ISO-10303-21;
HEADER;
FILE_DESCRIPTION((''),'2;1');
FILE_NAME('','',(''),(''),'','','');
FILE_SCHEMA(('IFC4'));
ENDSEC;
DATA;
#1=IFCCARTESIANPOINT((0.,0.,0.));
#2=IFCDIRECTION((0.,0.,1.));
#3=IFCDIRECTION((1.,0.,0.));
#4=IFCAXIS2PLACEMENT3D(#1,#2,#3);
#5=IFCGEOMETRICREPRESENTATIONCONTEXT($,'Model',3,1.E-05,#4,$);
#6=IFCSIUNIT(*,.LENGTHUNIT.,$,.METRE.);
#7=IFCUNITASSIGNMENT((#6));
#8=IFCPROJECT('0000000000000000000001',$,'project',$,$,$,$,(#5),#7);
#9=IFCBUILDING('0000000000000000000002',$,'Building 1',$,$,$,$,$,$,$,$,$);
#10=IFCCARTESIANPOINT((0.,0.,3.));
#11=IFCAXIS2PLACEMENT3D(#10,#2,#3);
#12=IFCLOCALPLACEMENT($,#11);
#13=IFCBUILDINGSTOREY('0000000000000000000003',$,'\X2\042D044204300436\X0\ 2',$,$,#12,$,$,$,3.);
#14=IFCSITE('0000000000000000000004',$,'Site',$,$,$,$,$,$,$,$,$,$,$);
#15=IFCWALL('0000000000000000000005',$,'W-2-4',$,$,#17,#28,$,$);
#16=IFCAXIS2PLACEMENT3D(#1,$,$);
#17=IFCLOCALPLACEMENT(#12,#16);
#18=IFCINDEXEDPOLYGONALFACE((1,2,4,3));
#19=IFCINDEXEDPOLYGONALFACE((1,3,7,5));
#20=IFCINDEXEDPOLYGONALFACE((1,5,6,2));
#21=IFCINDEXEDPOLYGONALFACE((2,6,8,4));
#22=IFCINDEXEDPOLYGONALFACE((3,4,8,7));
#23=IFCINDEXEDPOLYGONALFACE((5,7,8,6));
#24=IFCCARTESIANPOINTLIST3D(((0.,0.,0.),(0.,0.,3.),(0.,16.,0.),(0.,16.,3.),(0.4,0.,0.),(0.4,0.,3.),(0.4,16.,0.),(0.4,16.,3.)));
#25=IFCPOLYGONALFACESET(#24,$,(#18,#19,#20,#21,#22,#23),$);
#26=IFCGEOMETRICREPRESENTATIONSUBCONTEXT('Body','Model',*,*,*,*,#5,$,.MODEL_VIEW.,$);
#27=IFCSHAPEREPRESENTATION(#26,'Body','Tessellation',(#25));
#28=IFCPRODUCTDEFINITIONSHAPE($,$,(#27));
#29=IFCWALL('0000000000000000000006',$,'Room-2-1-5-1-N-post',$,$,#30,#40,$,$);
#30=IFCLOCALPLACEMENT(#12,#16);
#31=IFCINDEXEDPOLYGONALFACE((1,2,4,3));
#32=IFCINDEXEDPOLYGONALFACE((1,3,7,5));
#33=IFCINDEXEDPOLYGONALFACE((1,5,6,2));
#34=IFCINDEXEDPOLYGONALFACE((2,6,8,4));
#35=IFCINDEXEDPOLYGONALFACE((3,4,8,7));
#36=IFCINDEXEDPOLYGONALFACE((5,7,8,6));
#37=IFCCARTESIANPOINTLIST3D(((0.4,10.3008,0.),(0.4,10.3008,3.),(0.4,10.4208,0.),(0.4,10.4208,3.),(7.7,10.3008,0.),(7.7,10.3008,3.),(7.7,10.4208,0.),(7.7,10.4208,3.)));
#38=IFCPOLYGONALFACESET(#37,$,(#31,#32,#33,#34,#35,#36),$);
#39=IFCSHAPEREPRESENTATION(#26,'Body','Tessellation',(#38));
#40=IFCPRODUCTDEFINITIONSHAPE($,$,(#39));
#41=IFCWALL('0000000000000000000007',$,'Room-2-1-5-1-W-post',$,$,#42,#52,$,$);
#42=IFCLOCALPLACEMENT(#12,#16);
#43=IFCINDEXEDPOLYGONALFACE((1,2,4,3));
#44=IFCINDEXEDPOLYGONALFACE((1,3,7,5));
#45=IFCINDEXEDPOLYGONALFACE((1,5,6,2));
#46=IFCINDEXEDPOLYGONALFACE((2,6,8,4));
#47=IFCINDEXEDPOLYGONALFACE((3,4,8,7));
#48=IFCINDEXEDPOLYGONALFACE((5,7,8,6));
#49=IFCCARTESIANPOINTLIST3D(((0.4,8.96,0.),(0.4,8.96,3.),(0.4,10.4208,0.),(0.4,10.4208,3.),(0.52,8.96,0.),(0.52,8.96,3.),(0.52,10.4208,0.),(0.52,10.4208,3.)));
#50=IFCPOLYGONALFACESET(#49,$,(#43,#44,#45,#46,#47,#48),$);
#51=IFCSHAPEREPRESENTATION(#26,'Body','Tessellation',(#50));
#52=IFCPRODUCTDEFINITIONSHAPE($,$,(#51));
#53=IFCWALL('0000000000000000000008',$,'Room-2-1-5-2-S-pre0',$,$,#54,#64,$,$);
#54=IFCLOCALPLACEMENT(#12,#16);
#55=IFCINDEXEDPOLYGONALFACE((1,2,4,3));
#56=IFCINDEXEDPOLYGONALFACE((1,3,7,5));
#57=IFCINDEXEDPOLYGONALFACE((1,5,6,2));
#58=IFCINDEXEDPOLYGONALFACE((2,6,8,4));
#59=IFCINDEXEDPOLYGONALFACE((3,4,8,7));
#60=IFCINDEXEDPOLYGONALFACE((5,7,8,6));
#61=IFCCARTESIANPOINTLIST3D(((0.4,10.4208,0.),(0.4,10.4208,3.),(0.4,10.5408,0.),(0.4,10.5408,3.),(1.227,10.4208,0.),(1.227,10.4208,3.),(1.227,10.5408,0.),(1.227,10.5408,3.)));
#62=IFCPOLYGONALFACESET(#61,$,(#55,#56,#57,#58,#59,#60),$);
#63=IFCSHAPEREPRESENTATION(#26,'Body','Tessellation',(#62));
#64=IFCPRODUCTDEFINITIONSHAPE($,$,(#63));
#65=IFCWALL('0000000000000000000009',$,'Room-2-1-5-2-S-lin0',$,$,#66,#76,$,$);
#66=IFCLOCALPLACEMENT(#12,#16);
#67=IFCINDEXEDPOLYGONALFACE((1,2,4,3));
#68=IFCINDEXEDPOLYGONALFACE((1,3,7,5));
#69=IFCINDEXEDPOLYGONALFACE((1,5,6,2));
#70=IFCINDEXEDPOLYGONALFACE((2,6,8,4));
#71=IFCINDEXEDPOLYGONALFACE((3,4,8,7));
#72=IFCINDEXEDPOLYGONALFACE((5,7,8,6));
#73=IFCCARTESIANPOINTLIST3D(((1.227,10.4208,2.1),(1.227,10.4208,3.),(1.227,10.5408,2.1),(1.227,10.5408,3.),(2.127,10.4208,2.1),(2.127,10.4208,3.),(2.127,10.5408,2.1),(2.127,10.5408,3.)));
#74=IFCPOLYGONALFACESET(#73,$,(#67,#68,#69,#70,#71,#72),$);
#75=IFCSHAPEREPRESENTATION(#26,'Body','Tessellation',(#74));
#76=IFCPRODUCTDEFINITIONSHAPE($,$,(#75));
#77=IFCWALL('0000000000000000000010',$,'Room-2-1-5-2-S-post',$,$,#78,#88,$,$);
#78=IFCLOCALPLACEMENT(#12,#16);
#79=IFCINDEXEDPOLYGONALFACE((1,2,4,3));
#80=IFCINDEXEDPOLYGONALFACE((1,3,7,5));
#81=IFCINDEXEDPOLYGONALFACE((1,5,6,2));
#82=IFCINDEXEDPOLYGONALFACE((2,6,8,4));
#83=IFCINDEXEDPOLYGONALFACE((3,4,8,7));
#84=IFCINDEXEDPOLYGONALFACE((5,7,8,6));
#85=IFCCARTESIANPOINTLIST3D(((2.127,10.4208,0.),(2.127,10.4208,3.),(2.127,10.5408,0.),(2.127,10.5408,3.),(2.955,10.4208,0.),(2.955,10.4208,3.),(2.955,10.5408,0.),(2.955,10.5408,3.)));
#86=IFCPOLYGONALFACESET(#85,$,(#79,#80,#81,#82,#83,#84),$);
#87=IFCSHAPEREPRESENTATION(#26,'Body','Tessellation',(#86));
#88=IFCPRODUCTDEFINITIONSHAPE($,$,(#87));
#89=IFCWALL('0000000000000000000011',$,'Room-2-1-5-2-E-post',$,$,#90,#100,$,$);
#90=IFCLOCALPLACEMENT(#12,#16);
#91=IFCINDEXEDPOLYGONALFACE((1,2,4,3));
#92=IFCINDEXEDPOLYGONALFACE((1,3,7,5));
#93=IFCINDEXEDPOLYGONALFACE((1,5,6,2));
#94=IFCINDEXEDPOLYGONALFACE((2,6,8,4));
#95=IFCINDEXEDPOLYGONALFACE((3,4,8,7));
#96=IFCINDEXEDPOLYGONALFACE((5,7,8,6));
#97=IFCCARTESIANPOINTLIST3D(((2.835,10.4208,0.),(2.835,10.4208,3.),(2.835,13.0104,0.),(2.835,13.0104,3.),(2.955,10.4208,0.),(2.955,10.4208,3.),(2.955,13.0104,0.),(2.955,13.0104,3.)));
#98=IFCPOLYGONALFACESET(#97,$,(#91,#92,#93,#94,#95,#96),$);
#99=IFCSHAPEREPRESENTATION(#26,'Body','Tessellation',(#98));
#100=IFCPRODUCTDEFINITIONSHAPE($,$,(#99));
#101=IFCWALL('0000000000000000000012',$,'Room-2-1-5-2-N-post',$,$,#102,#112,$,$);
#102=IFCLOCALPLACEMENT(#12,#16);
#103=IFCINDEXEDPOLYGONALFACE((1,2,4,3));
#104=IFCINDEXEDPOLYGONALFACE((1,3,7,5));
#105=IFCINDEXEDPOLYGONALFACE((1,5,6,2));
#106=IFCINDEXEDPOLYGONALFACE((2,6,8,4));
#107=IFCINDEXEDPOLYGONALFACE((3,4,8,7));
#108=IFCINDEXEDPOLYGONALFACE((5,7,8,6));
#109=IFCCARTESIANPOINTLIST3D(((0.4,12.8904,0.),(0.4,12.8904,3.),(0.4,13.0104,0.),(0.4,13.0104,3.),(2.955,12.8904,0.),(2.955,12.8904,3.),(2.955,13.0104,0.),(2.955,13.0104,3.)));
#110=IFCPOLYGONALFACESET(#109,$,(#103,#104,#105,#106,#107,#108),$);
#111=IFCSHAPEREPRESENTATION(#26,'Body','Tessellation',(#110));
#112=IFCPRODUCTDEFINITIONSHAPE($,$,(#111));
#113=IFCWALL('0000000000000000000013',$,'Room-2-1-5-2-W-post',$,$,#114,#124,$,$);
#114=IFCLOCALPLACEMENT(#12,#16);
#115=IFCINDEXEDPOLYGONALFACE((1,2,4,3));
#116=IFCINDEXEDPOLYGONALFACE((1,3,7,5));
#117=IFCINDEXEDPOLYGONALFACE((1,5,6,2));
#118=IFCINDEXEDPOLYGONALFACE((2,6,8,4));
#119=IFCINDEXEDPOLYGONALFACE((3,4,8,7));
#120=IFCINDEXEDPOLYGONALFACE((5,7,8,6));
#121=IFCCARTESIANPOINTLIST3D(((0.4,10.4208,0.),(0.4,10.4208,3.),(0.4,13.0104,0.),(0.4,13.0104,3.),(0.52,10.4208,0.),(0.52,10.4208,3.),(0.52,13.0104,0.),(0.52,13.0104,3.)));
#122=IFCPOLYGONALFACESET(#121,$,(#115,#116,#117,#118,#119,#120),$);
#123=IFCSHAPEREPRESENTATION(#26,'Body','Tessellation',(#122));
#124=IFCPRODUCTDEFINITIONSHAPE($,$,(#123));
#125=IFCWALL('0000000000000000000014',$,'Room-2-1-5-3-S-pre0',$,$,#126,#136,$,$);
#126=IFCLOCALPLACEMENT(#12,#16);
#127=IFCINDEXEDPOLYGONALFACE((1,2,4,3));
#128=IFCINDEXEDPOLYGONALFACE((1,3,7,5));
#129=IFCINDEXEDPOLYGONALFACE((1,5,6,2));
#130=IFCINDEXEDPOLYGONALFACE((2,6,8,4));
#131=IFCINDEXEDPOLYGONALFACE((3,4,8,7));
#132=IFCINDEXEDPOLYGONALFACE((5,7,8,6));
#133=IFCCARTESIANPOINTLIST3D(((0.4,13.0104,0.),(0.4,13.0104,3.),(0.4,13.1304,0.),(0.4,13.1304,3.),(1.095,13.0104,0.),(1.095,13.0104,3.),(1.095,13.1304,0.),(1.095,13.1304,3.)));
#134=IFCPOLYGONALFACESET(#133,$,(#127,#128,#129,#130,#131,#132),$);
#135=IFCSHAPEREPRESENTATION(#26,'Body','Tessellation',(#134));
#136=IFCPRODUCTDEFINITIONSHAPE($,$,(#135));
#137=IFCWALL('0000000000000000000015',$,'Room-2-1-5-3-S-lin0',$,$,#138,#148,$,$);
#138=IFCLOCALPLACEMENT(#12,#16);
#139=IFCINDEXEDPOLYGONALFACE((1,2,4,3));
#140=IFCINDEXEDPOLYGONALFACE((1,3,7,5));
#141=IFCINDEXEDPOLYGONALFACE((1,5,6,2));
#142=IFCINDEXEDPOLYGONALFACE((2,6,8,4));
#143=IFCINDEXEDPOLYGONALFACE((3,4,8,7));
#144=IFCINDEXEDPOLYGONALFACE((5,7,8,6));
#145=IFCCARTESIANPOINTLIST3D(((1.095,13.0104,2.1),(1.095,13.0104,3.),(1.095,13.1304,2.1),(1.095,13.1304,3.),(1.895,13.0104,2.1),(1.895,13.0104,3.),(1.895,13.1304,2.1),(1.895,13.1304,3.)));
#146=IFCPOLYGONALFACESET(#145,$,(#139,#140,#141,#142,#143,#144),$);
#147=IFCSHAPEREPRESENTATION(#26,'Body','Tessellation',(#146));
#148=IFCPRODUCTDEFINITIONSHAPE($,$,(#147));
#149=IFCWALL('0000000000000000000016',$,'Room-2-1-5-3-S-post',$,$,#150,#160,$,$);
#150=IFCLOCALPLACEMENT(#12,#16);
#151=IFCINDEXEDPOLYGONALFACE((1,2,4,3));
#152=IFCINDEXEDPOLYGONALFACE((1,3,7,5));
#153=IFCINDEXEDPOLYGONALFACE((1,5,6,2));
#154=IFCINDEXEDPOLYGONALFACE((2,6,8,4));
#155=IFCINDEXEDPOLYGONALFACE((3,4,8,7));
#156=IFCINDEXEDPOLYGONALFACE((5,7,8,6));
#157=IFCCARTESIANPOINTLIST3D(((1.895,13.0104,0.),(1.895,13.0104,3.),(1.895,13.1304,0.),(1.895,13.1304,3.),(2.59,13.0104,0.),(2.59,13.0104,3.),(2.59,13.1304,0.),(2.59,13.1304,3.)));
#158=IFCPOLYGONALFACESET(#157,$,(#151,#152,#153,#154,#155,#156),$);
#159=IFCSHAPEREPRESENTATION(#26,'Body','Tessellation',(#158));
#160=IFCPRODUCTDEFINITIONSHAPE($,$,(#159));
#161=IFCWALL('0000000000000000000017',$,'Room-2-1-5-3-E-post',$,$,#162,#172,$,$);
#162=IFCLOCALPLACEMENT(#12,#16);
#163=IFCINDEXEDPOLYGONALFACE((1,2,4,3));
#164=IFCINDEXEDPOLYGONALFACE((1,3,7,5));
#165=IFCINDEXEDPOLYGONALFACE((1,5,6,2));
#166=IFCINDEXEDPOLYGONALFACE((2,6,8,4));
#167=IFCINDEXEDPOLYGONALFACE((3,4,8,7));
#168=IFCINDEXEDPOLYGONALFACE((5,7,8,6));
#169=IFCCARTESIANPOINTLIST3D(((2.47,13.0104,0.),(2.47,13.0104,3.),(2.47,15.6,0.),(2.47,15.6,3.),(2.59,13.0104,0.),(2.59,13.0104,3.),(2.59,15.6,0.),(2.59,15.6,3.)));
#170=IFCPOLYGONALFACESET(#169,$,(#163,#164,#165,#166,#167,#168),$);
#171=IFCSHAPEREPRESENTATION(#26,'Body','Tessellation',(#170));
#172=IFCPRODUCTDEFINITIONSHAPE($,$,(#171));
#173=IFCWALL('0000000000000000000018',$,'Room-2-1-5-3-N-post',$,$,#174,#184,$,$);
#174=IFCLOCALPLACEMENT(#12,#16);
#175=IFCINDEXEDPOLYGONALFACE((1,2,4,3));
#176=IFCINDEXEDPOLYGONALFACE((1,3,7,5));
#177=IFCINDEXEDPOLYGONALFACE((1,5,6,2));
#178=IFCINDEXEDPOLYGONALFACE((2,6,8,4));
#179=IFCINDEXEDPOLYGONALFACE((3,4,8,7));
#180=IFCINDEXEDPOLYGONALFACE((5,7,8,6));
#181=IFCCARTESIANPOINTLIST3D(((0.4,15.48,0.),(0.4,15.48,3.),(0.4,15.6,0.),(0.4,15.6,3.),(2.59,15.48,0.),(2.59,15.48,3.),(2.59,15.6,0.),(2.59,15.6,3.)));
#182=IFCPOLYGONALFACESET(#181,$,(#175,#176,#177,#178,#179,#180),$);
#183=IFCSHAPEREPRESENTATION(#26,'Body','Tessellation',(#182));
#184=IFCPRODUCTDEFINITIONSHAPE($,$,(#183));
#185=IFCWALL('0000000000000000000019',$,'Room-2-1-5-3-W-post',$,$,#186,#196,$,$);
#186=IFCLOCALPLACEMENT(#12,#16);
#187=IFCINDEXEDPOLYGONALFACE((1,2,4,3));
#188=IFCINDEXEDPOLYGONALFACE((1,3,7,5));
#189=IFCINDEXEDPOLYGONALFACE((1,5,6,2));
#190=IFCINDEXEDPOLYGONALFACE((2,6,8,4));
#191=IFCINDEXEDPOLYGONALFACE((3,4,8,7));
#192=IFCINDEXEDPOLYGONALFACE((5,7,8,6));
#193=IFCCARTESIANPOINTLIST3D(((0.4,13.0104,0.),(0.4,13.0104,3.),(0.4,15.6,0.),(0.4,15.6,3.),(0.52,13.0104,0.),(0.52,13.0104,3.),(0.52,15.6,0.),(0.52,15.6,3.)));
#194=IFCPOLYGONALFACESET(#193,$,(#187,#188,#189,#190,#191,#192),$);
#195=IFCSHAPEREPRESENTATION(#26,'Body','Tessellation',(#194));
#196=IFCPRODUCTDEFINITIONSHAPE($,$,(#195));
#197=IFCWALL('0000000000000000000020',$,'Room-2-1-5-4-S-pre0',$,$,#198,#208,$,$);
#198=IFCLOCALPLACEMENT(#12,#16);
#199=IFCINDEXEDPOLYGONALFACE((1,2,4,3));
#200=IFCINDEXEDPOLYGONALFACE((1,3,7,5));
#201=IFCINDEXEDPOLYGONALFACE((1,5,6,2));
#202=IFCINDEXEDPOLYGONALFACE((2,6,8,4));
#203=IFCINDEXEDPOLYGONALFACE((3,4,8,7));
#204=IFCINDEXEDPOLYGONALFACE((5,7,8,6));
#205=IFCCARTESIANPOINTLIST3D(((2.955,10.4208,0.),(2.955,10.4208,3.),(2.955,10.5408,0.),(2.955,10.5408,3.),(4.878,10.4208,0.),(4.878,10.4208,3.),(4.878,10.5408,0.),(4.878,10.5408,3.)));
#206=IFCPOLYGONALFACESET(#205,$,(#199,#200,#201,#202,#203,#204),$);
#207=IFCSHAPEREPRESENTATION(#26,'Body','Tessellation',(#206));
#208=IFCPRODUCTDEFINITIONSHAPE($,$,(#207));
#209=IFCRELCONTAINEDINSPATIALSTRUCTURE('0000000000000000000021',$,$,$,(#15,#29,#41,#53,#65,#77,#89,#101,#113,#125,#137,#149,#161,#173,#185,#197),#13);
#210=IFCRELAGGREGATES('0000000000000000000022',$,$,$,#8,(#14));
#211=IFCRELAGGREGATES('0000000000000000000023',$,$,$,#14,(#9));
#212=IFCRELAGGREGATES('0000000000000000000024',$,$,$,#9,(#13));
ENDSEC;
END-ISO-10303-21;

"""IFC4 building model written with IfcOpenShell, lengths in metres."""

from ifc_helpers import new_model, si_unit, frame, origin_with_axes, place, context, subcontext, project, spatial, indexed_curve, outline, extrude, element, save


model = new_model("IFC4")

# Units and contexts
model_context = context("Model", 3, precision=1e-05, world=origin_with_axes())
body_context = subcontext(model_context, "Body", "Model", "MODEL_VIEW")
ifc_project = project(units=[si_unit("LENGTHUNIT", "METRE")], contexts=[model_context])

# Site, building, storey
site = spatial("IfcSite", under=ifc_project, Name="Site")
building = spatial("IfcBuilding", under=site, Name="Building 1")
storey_placement = place(None, frame((0.0, 0.0, 3.0), z_axis=(0.0, 0.0, 1.0), x_axis=(1.0, 0.0, 0.0)))
storey = spatial("IfcBuildingStorey", under=building, at=storey_placement, Name="Этаж 2", Elevation=3.0)

# Walls
wall_1_placement = place(storey_placement, frame((0.0, 16.0, 0.0), z_axis=(0.0, 0.0, 1.0), x_axis=(0.0, -1.0, 0.0)))
element("IfcWall", 1, at=wall_1_placement, inside=storey, Name="W-2-4", context=body_context, shape_type="SweptSolid", body=[
    extrude(outline(indexed_curve([(0.0, 0.0), (0.0, 0.4), (16.0, 0.4), (16.0, 0.0), (0.0, 0.0)], self_intersect=False)), origin_with_axes(), (0.0, 0.0, 1.0), 3.0),
])
wall_2_placement = place(storey_placement, frame((7.7, 10.4208, 0.0), z_axis=(0.0, 0.0, 1.0), x_axis=(-1.0, 0.0, 0.0)))
element("IfcWall", 2, at=wall_2_placement, inside=storey, Name="Room-2-1-5-1-N-post", context=body_context, shape_type="SweptSolid", body=[
    extrude(outline(indexed_curve([(0.0, 0.0), (0.0, 0.12), (7.3, 0.12), (7.3, 0.0), (0.0, 0.0)], self_intersect=False)), origin_with_axes(), (0.0, 0.0, 1.0), 3.0),
])
wall_3_placement = place(storey_placement, frame((0.4, 10.4208, 0.0), z_axis=(0.0, 0.0, 1.0), x_axis=(0.0, -1.0, 0.0)))
element("IfcWall", 3, at=wall_3_placement, inside=storey, Name="Room-2-1-5-1-W-post", context=body_context, shape_type="SweptSolid", body=[
    extrude(outline(indexed_curve([(0.0, 0.0), (0.0, 0.12), (1.4608, 0.12), (1.4608, 0.0), (0.0, 0.0)], self_intersect=False)), origin_with_axes(), (0.0, 0.0, 1.0), 3.0),
])
wall_4_placement = place(storey_placement, frame((0.4, 10.4208, 0.0), z_axis=(0.0, 0.0, 1.0), x_axis=(1.0, 0.0, 0.0)))
element("IfcWall", 4, at=wall_4_placement, inside=storey, Name="Room-2-1-5-2-S-pre0", context=body_context, shape_type="SweptSolid", body=[
    extrude(outline(indexed_curve([(0.0, 0.0), (0.0, 0.12), (0.827, 0.12), (0.827, 0.0), (0.0, 0.0)], self_intersect=False)), origin_with_axes(), (0.0, 0.0, 1.0), 3.0),
])
wall_5_placement = place(storey_placement, frame((1.227, 10.4208, 2.1), z_axis=(0.0, 0.0, 1.0), x_axis=(1.0, 0.0, 0.0)))
element("IfcWall", 5, at=wall_5_placement, inside=storey, Name="Room-2-1-5-2-S-lin0", context=body_context, shape_type="SweptSolid", body=[
    extrude(outline(indexed_curve([(0.0, 0.0), (0.0, 0.12), (0.9, 0.12), (0.9, 0.0), (0.0, 0.0)], self_intersect=False)), origin_with_axes(), (0.0, 0.0, 1.0), 0.9),
])
wall_6_placement = place(storey_placement, frame((2.127, 10.4208, 0.0), z_axis=(0.0, 0.0, 1.0), x_axis=(1.0, 0.0, 0.0)))
element("IfcWall", 6, at=wall_6_placement, inside=storey, Name="Room-2-1-5-2-S-post", context=body_context, shape_type="SweptSolid", body=[
    extrude(outline(indexed_curve([(0.0, 0.0), (0.0, 0.12), (0.828, 0.12), (0.828, 0.0), (0.0, 0.0)], self_intersect=False)), origin_with_axes(), (0.0, 0.0, 1.0), 3.0),
])
wall_7_placement = place(storey_placement, frame((2.955, 10.4208, 0.0), z_axis=(0.0, 0.0, 1.0), x_axis=(0.0, 1.0, 0.0)))
element("IfcWall", 7, at=wall_7_placement, inside=storey, Name="Room-2-1-5-2-E-post", context=body_context, shape_type="SweptSolid", body=[
    extrude(outline(indexed_curve([(0.0, 0.0), (0.0, 0.12), (2.5896, 0.12), (2.5896, 0.0), (0.0, 0.0)], self_intersect=False)), origin_with_axes(), (0.0, 0.0, 1.0), 3.0),
])
wall_8_placement = place(storey_placement, frame((2.955, 13.0104, 0.0), z_axis=(0.0, 0.0, 1.0), x_axis=(-1.0, 0.0, 0.0)))
element("IfcWall", 8, at=wall_8_placement, inside=storey, Name="Room-2-1-5-2-N-post", context=body_context, shape_type="SweptSolid", body=[
    extrude(outline(indexed_curve([(0.0, 0.0), (0.0, 0.12), (2.555, 0.12), (2.555, 0.0), (0.0, 0.0)], self_intersect=False)), origin_with_axes(), (0.0, 0.0, 1.0), 3.0),
])
wall_9_placement = place(storey_placement, frame((0.4, 13.0104, 0.0), z_axis=(0.0, 0.0, 1.0), x_axis=(0.0, -1.0, 0.0)))
element("IfcWall", 9, at=wall_9_placement, inside=storey, Name="Room-2-1-5-2-W-post", context=body_context, shape_type="SweptSolid", body=[
    extrude(outline(indexed_curve([(0.0, 0.0), (0.0, 0.12), (2.5896, 0.12), (2.5896, 0.0), (0.0, 0.0)], self_intersect=False)), origin_with_axes(), (0.0, 0.0, 1.0), 3.0),
])
wall_10_placement = place(storey_placement, frame((0.4, 13.0104, 0.0), z_axis=(0.0, 0.0, 1.0), x_axis=(1.0, 0.0, 0.0)))
element("IfcWall", 10, at=wall_10_placement, inside=storey, Name="Room-2-1-5-3-S-pre0", context=body_context, shape_type="SweptSolid", body=[
    extrude(outline(indexed_curve([(0.0, 0.0), (0.0, 0.12), (0.695, 0.12), (0.695, 0.0), (0.0, 0.0)], self_intersect=False)), origin_with_axes(), (0.0, 0.0, 1.0), 3.0),
])
wall_11_placement = place(storey_placement, frame((1.095, 13.0104, 2.1), z_axis=(0.0, 0.0, 1.0), x_axis=(1.0, 0.0, 0.0)))
element("IfcWall", 11, at=wall_11_placement, inside=storey, Name="Room-2-1-5-3-S-lin0", context=body_context, shape_type="SweptSolid", body=[
    extrude(outline(indexed_curve([(0.0, 0.0), (0.0, 0.12), (0.8, 0.12), (0.8, 0.0), (0.0, 0.0)], self_intersect=False)), origin_with_axes(), (0.0, 0.0, 1.0), 0.9),
])
wall_12_placement = place(storey_placement, frame((1.895, 13.0104, 0.0), z_axis=(0.0, 0.0, 1.0), x_axis=(1.0, 0.0, 0.0)))
element("IfcWall", 12, at=wall_12_placement, inside=storey, Name="Room-2-1-5-3-S-post", context=body_context, shape_type="SweptSolid", body=[
    extrude(outline(indexed_curve([(0.0, 0.0), (0.0, 0.12), (0.695, 0.12), (0.695, 0.0), (0.0, 0.0)], self_intersect=False)), origin_with_axes(), (0.0, 0.0, 1.0), 3.0),
])
wall_13_placement = place(storey_placement, frame((2.59, 13.0104, 0.0), z_axis=(0.0, 0.0, 1.0), x_axis=(0.0, 1.0, 0.0)))
element("IfcWall", 13, at=wall_13_placement, inside=storey, Name="Room-2-1-5-3-E-post", context=body_context, shape_type="SweptSolid", body=[
    extrude(outline(indexed_curve([(0.0, 0.0), (0.0, 0.12), (2.5896, 0.12), (2.5896, 0.0), (0.0, 0.0)], self_intersect=False)), origin_with_axes(), (0.0, 0.0, 1.0), 3.0),
])
wall_14_placement = place(storey_placement, frame((2.59, 15.6, 0.0), z_axis=(0.0, 0.0, 1.0), x_axis=(-1.0, 0.0, 0.0)))
element("IfcWall", 14, at=wall_14_placement, inside=storey, Name="Room-2-1-5-3-N-post", context=body_context, shape_type="SweptSolid", body=[
    extrude(outline(indexed_curve([(0.0, 0.0), (0.0, 0.12), (2.19, 0.12), (2.19, 0.0), (0.0, 0.0)], self_intersect=False)), origin_with_axes(), (0.0, 0.0, 1.0), 3.0),
])
wall_15_placement = place(storey_placement, frame((0.4, 15.6, 0.0), z_axis=(0.0, 0.0, 1.0), x_axis=(0.0, -1.0, 0.0)))
element("IfcWall", 15, at=wall_15_placement, inside=storey, Name="Room-2-1-5-3-W-post", context=body_context, shape_type="SweptSolid", body=[
    extrude(outline(indexed_curve([(0.0, 0.0), (0.0, 0.12), (2.5896, 0.12), (2.5896, 0.0), (0.0, 0.0)], self_intersect=False)), origin_with_axes(), (0.0, 0.0, 1.0), 3.0),
])
wall_16_placement = place(storey_placement, frame((2.955, 10.4208, 0.0), z_axis=(0.0, 0.0, 1.0), x_axis=(1.0, 0.0, 0.0)))
element("IfcWall", 16, at=wall_16_placement, inside=storey, Name="Room-2-1-5-4-S-pre0", context=body_context, shape_type="SweptSolid", body=[
    extrude(outline(indexed_curve([(0.0, 0.0), (0.0, 0.12), (1.923, 0.12), (1.923, 0.0), (0.0, 0.0)], self_intersect=False)), origin_with_axes(), (0.0, 0.0, 1.0), 3.0),
])

save(model, "model.ifc")
